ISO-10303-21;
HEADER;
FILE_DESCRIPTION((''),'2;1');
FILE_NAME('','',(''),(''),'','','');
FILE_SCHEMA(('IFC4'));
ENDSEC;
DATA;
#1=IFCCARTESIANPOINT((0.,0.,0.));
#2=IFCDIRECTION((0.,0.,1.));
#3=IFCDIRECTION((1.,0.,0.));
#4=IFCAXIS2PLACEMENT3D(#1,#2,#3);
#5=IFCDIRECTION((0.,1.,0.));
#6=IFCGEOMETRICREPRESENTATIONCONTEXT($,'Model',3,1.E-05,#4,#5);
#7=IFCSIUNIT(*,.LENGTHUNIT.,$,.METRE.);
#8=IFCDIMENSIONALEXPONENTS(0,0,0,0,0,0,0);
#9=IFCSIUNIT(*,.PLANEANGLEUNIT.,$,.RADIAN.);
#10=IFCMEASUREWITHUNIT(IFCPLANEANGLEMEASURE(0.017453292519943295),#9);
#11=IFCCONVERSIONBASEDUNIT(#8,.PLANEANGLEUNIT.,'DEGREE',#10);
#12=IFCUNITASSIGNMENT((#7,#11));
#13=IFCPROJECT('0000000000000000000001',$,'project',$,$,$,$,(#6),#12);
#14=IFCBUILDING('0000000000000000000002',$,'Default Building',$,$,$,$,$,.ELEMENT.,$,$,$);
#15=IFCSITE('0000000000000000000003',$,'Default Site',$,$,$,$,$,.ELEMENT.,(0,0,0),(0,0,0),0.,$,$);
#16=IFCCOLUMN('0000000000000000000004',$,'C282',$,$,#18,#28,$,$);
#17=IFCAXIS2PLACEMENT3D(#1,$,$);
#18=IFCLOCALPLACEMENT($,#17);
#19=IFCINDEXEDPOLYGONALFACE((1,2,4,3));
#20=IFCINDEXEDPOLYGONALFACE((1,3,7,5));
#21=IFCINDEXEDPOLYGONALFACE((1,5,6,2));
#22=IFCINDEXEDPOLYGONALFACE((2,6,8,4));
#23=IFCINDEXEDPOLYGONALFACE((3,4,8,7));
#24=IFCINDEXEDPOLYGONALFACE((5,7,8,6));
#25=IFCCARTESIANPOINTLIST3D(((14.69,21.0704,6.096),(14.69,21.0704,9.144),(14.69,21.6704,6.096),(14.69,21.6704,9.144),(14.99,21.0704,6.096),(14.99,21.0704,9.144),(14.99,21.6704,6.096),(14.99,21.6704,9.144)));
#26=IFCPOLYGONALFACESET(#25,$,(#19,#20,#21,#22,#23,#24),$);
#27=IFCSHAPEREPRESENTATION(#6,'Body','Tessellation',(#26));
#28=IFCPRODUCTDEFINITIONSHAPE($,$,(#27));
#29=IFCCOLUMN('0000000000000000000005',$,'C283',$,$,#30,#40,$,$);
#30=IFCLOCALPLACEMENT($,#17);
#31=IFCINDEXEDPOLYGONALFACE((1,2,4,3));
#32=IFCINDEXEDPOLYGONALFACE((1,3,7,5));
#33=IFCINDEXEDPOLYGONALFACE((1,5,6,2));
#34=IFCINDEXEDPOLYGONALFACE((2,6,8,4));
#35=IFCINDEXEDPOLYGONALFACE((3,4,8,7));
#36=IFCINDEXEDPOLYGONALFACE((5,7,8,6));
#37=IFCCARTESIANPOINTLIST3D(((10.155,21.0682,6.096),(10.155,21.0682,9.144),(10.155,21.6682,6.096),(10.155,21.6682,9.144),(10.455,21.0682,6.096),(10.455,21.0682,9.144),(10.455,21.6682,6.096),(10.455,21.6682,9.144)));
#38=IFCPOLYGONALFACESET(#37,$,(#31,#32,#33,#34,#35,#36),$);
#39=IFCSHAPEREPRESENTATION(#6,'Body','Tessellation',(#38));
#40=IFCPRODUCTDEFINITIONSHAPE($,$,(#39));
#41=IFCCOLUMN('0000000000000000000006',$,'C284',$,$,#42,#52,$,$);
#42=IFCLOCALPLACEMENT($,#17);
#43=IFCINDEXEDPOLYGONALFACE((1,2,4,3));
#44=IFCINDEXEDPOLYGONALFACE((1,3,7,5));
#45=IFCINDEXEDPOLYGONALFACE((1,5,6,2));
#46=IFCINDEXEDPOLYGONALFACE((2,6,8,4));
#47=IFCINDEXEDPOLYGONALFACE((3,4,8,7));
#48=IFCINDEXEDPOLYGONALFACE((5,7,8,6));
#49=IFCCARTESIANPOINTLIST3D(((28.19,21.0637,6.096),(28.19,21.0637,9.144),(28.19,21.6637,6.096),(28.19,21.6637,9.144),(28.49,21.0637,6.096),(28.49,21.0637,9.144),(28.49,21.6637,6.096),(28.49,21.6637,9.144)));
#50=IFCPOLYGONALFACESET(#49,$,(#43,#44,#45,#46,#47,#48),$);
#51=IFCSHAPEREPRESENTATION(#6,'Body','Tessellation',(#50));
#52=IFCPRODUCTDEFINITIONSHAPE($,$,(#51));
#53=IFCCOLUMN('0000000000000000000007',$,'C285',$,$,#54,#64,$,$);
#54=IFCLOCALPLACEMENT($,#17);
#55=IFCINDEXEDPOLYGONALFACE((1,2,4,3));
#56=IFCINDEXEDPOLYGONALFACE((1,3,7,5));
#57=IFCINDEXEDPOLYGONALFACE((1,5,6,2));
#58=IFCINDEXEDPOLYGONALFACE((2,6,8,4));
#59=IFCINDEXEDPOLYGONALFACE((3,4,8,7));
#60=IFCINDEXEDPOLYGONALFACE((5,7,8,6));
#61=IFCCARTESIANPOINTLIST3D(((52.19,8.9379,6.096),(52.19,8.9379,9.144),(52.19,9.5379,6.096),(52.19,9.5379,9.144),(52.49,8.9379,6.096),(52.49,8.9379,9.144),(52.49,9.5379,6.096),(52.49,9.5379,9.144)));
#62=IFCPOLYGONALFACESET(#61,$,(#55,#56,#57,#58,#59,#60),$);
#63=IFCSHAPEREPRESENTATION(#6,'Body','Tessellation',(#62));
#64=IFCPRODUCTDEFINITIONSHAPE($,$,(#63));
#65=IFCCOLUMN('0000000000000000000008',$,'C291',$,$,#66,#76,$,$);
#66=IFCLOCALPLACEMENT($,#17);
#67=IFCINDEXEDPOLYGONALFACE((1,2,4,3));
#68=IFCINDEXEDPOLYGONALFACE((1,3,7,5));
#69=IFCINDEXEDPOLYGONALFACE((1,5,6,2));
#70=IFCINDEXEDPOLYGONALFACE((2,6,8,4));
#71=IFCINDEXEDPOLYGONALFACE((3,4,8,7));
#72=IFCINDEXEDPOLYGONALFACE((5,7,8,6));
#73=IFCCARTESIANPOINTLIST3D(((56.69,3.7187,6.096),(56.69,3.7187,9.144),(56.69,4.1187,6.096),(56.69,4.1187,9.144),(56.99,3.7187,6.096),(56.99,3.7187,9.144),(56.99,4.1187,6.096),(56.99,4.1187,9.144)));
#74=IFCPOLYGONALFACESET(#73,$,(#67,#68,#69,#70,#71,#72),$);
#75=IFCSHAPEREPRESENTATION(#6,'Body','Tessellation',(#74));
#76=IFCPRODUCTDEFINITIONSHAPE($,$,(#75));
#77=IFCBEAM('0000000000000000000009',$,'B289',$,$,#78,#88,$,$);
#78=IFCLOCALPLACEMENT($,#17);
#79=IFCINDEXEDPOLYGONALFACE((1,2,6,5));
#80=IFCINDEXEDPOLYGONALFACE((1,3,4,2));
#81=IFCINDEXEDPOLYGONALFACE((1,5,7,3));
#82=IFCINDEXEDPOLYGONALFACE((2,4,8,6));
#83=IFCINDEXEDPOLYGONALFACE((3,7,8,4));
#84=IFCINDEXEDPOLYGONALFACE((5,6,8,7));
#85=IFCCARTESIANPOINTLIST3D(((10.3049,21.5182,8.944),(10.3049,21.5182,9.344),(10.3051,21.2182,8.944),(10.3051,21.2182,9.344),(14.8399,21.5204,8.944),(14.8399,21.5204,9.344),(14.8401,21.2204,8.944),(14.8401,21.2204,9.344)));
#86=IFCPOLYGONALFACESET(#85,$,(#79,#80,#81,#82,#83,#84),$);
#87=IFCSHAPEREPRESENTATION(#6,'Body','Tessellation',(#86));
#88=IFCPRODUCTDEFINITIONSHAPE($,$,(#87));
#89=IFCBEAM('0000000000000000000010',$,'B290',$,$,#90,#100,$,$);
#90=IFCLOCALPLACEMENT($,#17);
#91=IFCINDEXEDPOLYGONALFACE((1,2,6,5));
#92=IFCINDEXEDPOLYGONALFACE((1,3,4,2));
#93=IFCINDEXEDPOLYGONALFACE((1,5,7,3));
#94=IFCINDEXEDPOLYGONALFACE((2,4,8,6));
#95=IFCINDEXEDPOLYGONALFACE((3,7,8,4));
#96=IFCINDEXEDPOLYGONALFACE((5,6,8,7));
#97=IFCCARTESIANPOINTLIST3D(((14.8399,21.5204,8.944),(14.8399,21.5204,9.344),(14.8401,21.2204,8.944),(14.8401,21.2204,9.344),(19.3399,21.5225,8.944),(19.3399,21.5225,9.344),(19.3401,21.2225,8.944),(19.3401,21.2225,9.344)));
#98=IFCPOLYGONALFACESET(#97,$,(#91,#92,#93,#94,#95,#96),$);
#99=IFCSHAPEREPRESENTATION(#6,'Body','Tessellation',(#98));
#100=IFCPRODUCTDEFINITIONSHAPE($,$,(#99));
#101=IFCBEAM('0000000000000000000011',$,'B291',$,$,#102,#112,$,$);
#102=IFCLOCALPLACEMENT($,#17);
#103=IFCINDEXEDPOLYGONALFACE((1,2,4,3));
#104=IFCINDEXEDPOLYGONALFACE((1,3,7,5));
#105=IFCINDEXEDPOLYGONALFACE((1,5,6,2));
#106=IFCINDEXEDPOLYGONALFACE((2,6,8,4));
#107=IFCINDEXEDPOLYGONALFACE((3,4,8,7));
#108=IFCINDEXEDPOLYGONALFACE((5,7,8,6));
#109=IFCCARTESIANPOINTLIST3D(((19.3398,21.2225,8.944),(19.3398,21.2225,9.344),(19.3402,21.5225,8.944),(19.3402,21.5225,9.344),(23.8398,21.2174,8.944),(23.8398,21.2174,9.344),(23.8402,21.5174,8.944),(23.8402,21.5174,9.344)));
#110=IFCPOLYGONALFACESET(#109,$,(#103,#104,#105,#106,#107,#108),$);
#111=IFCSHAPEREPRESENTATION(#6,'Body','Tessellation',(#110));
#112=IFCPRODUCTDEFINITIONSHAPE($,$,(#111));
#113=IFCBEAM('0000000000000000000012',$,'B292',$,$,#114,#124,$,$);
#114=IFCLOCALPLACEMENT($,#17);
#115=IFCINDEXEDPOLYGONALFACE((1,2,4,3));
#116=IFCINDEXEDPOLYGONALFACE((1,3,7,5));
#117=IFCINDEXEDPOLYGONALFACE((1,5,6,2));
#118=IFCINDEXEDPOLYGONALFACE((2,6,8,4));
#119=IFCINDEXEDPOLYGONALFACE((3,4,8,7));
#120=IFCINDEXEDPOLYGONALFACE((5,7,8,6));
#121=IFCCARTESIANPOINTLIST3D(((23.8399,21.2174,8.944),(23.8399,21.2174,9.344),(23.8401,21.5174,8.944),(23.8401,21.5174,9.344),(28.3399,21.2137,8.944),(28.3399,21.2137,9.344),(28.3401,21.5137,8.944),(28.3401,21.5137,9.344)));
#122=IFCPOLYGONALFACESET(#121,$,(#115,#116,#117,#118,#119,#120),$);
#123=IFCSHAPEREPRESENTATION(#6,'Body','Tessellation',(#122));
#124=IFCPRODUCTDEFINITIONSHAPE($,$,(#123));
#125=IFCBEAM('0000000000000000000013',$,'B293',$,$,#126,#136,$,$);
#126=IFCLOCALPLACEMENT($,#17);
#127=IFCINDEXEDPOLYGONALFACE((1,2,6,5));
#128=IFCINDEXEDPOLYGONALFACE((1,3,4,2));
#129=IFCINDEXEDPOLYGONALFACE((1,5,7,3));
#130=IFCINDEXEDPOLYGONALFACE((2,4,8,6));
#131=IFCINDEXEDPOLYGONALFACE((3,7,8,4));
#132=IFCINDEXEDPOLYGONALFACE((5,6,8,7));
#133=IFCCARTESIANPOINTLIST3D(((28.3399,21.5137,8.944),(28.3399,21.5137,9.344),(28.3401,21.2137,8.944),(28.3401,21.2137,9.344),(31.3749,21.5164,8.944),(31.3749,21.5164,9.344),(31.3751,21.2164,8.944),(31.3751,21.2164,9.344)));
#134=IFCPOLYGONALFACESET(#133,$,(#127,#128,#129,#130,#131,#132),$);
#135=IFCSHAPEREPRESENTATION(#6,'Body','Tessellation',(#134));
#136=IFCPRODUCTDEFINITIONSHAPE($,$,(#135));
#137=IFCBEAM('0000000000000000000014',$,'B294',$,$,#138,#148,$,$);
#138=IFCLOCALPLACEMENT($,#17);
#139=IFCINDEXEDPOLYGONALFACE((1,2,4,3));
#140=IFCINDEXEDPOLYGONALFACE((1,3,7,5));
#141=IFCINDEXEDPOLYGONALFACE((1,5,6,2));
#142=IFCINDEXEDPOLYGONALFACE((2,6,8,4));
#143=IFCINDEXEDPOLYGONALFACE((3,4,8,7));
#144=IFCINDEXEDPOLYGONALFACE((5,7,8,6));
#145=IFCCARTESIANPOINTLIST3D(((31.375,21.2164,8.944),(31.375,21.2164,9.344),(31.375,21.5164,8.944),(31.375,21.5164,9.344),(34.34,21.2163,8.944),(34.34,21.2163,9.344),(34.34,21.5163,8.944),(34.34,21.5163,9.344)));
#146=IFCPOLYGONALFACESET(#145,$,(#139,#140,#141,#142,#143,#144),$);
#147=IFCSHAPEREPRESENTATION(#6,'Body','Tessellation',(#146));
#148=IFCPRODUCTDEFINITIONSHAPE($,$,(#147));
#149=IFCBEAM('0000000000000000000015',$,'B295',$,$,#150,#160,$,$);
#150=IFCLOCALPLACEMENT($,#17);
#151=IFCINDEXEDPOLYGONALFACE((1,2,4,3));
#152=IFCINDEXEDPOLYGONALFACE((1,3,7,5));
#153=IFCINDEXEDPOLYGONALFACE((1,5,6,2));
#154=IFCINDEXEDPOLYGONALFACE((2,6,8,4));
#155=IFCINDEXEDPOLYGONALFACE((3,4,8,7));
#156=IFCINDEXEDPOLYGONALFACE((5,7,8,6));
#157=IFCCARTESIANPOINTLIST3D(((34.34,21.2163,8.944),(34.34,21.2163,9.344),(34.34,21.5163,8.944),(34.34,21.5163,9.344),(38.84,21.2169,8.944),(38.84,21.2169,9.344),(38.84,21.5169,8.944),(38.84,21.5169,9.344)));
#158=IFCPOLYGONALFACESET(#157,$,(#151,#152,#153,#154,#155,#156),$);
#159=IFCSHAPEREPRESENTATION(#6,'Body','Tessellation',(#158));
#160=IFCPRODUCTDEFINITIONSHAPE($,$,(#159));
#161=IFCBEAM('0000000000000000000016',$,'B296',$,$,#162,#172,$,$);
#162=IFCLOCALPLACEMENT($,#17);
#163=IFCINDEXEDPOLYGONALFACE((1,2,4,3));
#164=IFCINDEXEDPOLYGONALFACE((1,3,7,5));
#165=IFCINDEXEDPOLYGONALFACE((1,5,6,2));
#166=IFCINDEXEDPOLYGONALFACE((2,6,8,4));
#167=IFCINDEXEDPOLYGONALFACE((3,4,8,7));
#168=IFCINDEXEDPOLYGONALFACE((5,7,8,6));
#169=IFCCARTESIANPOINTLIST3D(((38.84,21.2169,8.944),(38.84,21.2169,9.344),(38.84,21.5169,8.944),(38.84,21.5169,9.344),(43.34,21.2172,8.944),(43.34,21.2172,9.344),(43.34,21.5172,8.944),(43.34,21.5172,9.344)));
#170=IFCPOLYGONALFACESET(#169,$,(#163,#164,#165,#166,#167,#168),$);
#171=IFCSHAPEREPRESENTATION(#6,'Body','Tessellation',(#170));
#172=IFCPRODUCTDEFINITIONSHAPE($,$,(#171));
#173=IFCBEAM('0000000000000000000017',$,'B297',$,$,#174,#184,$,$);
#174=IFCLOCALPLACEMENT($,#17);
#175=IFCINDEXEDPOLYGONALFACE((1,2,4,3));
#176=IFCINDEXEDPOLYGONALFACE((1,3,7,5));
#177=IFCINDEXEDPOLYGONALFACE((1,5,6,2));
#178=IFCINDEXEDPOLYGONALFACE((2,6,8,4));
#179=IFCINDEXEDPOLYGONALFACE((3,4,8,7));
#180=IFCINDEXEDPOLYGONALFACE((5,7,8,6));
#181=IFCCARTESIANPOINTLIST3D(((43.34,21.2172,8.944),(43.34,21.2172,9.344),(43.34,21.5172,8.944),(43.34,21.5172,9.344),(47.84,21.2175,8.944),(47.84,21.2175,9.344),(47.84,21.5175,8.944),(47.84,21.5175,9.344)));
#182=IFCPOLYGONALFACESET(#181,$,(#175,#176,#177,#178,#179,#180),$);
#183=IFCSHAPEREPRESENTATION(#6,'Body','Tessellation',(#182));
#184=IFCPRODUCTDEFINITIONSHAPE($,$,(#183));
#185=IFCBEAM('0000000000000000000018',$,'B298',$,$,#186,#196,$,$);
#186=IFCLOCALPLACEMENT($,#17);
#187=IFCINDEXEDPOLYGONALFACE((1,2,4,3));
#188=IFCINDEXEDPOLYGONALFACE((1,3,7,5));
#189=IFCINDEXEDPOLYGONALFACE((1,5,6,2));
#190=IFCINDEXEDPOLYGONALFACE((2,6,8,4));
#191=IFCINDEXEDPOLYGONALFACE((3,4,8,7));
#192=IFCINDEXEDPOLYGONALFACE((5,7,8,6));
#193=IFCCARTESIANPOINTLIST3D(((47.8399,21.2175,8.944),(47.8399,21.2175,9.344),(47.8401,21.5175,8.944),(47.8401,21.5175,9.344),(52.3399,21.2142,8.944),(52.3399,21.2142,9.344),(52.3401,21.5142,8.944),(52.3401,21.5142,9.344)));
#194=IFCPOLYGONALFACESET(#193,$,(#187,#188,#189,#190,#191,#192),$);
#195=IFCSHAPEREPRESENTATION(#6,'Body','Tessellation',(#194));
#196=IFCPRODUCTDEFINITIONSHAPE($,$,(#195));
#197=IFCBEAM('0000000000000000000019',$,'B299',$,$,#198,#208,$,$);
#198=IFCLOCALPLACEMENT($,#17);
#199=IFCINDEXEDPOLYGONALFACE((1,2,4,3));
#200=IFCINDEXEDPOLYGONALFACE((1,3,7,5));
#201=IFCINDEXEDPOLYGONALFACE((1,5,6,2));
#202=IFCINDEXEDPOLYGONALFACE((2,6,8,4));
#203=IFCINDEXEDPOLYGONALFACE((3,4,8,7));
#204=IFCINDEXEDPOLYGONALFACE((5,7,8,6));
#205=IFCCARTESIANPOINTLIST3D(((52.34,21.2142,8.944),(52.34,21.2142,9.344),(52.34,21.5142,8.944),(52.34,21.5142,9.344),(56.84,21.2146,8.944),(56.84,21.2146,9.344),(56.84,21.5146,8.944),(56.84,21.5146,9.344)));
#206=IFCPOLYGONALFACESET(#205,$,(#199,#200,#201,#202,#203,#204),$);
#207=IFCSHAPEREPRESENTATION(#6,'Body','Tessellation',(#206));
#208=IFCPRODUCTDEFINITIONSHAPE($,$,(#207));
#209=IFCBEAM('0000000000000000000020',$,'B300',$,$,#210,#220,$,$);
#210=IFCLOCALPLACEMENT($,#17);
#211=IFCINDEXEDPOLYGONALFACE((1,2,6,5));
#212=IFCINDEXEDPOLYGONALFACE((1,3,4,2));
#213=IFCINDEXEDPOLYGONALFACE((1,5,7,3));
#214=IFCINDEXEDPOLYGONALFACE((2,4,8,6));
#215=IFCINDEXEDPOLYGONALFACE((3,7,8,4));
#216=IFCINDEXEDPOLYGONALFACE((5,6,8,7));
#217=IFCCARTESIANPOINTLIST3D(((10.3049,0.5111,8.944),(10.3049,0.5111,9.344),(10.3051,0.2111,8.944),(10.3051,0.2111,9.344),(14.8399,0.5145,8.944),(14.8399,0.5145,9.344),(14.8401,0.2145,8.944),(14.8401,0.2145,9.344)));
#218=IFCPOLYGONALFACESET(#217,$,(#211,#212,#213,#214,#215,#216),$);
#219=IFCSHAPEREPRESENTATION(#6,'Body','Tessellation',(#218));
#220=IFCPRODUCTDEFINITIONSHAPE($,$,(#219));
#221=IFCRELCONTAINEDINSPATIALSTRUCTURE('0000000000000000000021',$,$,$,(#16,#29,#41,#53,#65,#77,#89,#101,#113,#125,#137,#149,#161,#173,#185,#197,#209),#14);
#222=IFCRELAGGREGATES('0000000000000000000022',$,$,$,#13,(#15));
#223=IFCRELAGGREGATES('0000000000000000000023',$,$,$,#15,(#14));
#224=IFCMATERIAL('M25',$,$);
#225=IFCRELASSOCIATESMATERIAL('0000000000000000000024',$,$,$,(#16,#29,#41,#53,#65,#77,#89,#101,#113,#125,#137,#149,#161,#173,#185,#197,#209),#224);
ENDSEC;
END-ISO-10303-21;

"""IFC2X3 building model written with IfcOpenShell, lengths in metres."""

from ifc_helpers import new_model, entity, si_unit, converted_unit, direction, frame, frame_2d, origin_with_axes, place, context, project, spatial, rectangle, extrude, material, element, save


model = new_model("IFC2X3")

# Units and contexts
model_context = context("Model", 3, precision=1e-05, world=origin_with_axes(), true_north=direction((0.0, 1.0, 0.0)))
ifc_project = project(units=[si_unit("LENGTHUNIT", "METRE"), converted_unit("PLANEANGLEUNIT", "DEGREE", entity("IfcPlaneAngleMeasure", 0.017453292519943295), si_unit("PLANEANGLEUNIT", "RADIAN"), dimensions=[0, 0, 0, 0, 0, 0, 0])], contexts=[model_context])

# Site, building
site = spatial("IfcSite", under=ifc_project, Name="Default Site", CompositionType="ELEMENT", RefLatitude=(0, 0, 0), RefLongitude=(0, 0, 0), RefElevation=0.0)
building = spatial("IfcBuilding", under=site, Name="Default Building", CompositionType="ELEMENT")

# Columns
ifc_material = material(Name="M25")
placement = place(None, origin_with_axes())
element("IfcColumn", 1, at=placement, inside=building, material=ifc_material, Name="C282", context=model_context, shape_type="SweptSolid", body=[
    extrude(rectangle(XDim=0.3, YDim=0.6, at=frame_2d((0.0, 0.0), x_axis=(1.0, 0.0, 0.0))), frame((14.84, 21.3704, 6.096), z_axis=(0.0, 0.0, 1.0), x_axis=(1.0, 0.0, 0.0)), (0.0, 0.0, 1.0), 3.048),
])
element("IfcColumn", 2, at=placement, inside=building, material=ifc_material, Name="C283", context=model_context, shape_type="SweptSolid", body=[
    extrude(rectangle(XDim=0.3, YDim=0.6, at=frame_2d((0.0, 0.0), x_axis=(1.0, 0.0, 0.0))), frame((10.305, 21.3682, 6.096), z_axis=(0.0, 0.0, 1.0), x_axis=(1.0, 0.0, 0.0)), (0.0, 0.0, 1.0), 3.048),
])
element("IfcColumn", 3, at=placement, inside=building, material=ifc_material, Name="C284", context=model_context, shape_type="SweptSolid", body=[
    extrude(rectangle(XDim=0.3, YDim=0.6, at=frame_2d((0.0, 0.0), x_axis=(1.0, 0.0, 0.0))), frame((28.34, 21.3637, 6.096), z_axis=(0.0, 0.0, 1.0), x_axis=(1.0, 0.0, 0.0)), (0.0, 0.0, 1.0), 3.048),
])
element("IfcColumn", 4, at=placement, inside=building, material=ifc_material, Name="C285", context=model_context, shape_type="SweptSolid", body=[
    extrude(rectangle(XDim=0.3, YDim=0.6, at=frame_2d((0.0, 0.0), x_axis=(1.0, 0.0, 0.0))), frame((52.34, 9.2379, 6.096), z_axis=(0.0, 0.0, 1.0), x_axis=(1.0, 0.0, 0.0)), (0.0, 0.0, 1.0), 3.048),
])
element("IfcColumn", 5, at=placement, inside=building, material=ifc_material, Name="C291", context=model_context, shape_type="SweptSolid", body=[
    extrude(rectangle(XDim=0.3, YDim=0.4, at=frame_2d((0.0, 0.0), x_axis=(1.0, 0.0, 0.0))), frame((56.84, 3.9187, 6.096), z_axis=(0.0, 0.0, 1.0), x_axis=(1.0, 0.0, 0.0)), (0.0, 0.0, 1.0), 3.048),
])

# Beams
element("IfcBeam", 6, at=placement, inside=building, material=ifc_material, Name="B289", context=model_context, shape_type="SweptSolid", body=[
    extrude(rectangle(XDim=0.3, YDim=0.4, at=frame_2d((0.0, 0.0), x_axis=(0.0, 1.0, 0.0))), frame((10.305, 21.3682, 9.144), z_axis=(1.0, 0.000476, 0.0), x_axis=(0.0, 0.0, -1.0)), (0.0, 0.0, 1.0), 4.535),
])
element("IfcBeam", 7, at=placement, inside=building, material=ifc_material, Name="B290", context=model_context, shape_type="SweptSolid", body=[
    extrude(rectangle(XDim=0.3, YDim=0.4, at=frame_2d((0.0, 0.0), x_axis=(0.0, 1.0, 0.0))), frame((14.84, 21.3704, 9.144), z_axis=(1.0, 0.000471, 0.0), x_axis=(0.0, 0.0, -1.0)), (0.0, 0.0, 1.0), 4.5),
])
element("IfcBeam", 8, at=placement, inside=building, material=ifc_material, Name="B291", context=model_context, shape_type="SweptSolid", body=[
    extrude(rectangle(XDim=0.3, YDim=0.4, at=frame_2d((0.0, 0.0), x_axis=(0.0, 1.0, 0.0))), frame((19.34, 21.3725, 9.144), z_axis=(0.999999, -0.001141, 0.0), x_axis=(0.0, 0.0, -1.0)), (0.0, 0.0, 1.0), 4.5),
])
element("IfcBeam", 9, at=placement, inside=building, material=ifc_material, Name="B292", context=model_context, shape_type="SweptSolid", body=[
    extrude(rectangle(XDim=0.3, YDim=0.4, at=frame_2d((0.0, 0.0), x_axis=(0.0, 1.0, 0.0))), frame((23.84, 21.3674, 9.144), z_axis=(1.0, -0.000812, 0.0), x_axis=(0.0, 0.0, -1.0)), (0.0, 0.0, 1.0), 4.5),
])
element("IfcBeam", 10, at=placement, inside=building, material=ifc_material, Name="B293", context=model_context, shape_type="SweptSolid", body=[
    extrude(rectangle(XDim=0.3, YDim=0.4, at=frame_2d((0.0, 0.0), x_axis=(0.0, 1.0, 0.0))), frame((28.34, 21.3637, 9.144), z_axis=(1.0, 0.000883, 0.0), x_axis=(0.0, 0.0, -1.0)), (0.0, 0.0, 1.0), 3.035),
])
element("IfcBeam", 11, at=placement, inside=building, material=ifc_material, Name="B294", context=model_context, shape_type="SweptSolid", body=[
    extrude(rectangle(XDim=0.3, YDim=0.4, at=frame_2d((0.0, 0.0), x_axis=(0.0, 1.0, 0.0))), frame((31.375, 21.3664, 9.144), z_axis=(1.0, -0.000016, 0.0), x_axis=(0.0, 0.0, -1.0)), (0.0, 0.0, 1.0), 2.965),
])
element("IfcBeam", 12, at=placement, inside=building, material=ifc_material, Name="B295", context=model_context, shape_type="SweptSolid", body=[
    extrude(rectangle(XDim=0.3, YDim=0.4, at=frame_2d((0.0, 0.0), x_axis=(0.0, 1.0, 0.0))), frame((34.34, 21.3663, 9.144), z_axis=(1.0, 0.000136, 0.0), x_axis=(0.0, 0.0, -1.0)), (0.0, 0.0, 1.0), 4.5),
])
element("IfcBeam", 13, at=placement, inside=building, material=ifc_material, Name="B296", context=model_context, shape_type="SweptSolid", body=[
    extrude(rectangle(XDim=0.3, YDim=0.4, at=frame_2d((0.0, 0.0), x_axis=(0.0, 1.0, 0.0))), frame((38.84, 21.3669, 9.144), z_axis=(1.0, 0.00005, 0.0), x_axis=(0.0, 0.0, -1.0)), (0.0, 0.0, 1.0), 4.5),
])
element("IfcBeam", 14, at=placement, inside=building, material=ifc_material, Name="B297", context=model_context, shape_type="SweptSolid", body=[
    extrude(rectangle(XDim=0.3, YDim=0.4, at=frame_2d((0.0, 0.0), x_axis=(0.0, 1.0, 0.0))), frame((43.34, 21.3672, 9.144), z_axis=(1.0, 0.000075, 0.0), x_axis=(0.0, 0.0, -1.0)), (0.0, 0.0, 1.0), 4.5),
])
element("IfcBeam", 15, at=placement, inside=building, material=ifc_material, Name="B298", context=model_context, shape_type="SweptSolid", body=[
    extrude(rectangle(XDim=0.3, YDim=0.4, at=frame_2d((0.0, 0.0), x_axis=(0.0, 1.0, 0.0))), frame((47.84, 21.3675, 9.144), z_axis=(1.0, -0.000744, 0.0), x_axis=(0.0, 0.0, -1.0)), (0.0, 0.0, 1.0), 4.5),
])
element("IfcBeam", 16, at=placement, inside=building, material=ifc_material, Name="B299", context=model_context, shape_type="SweptSolid", body=[
    extrude(rectangle(XDim=0.3, YDim=0.4, at=frame_2d((0.0, 0.0), x_axis=(0.0, 1.0, 0.0))), frame((52.34, 21.3642, 9.144), z_axis=(1.0, 0.000102, 0.0), x_axis=(0.0, 0.0, -1.0)), (0.0, 0.0, 1.0), 4.5),
])
element("IfcBeam", 17, at=placement, inside=building, material=ifc_material, Name="B300", context=model_context, shape_type="SweptSolid", body=[
    extrude(rectangle(XDim=0.3, YDim=0.4, at=frame_2d((0.0, 0.0), x_axis=(0.0, 1.0, 0.0))), frame((10.305, 0.3611, 9.144), z_axis=(1.0, 0.000762, 0.0), x_axis=(0.0, 0.0, -1.0)), (0.0, 0.0, 1.0), 4.535),
])

save(model, "model.ifc")
